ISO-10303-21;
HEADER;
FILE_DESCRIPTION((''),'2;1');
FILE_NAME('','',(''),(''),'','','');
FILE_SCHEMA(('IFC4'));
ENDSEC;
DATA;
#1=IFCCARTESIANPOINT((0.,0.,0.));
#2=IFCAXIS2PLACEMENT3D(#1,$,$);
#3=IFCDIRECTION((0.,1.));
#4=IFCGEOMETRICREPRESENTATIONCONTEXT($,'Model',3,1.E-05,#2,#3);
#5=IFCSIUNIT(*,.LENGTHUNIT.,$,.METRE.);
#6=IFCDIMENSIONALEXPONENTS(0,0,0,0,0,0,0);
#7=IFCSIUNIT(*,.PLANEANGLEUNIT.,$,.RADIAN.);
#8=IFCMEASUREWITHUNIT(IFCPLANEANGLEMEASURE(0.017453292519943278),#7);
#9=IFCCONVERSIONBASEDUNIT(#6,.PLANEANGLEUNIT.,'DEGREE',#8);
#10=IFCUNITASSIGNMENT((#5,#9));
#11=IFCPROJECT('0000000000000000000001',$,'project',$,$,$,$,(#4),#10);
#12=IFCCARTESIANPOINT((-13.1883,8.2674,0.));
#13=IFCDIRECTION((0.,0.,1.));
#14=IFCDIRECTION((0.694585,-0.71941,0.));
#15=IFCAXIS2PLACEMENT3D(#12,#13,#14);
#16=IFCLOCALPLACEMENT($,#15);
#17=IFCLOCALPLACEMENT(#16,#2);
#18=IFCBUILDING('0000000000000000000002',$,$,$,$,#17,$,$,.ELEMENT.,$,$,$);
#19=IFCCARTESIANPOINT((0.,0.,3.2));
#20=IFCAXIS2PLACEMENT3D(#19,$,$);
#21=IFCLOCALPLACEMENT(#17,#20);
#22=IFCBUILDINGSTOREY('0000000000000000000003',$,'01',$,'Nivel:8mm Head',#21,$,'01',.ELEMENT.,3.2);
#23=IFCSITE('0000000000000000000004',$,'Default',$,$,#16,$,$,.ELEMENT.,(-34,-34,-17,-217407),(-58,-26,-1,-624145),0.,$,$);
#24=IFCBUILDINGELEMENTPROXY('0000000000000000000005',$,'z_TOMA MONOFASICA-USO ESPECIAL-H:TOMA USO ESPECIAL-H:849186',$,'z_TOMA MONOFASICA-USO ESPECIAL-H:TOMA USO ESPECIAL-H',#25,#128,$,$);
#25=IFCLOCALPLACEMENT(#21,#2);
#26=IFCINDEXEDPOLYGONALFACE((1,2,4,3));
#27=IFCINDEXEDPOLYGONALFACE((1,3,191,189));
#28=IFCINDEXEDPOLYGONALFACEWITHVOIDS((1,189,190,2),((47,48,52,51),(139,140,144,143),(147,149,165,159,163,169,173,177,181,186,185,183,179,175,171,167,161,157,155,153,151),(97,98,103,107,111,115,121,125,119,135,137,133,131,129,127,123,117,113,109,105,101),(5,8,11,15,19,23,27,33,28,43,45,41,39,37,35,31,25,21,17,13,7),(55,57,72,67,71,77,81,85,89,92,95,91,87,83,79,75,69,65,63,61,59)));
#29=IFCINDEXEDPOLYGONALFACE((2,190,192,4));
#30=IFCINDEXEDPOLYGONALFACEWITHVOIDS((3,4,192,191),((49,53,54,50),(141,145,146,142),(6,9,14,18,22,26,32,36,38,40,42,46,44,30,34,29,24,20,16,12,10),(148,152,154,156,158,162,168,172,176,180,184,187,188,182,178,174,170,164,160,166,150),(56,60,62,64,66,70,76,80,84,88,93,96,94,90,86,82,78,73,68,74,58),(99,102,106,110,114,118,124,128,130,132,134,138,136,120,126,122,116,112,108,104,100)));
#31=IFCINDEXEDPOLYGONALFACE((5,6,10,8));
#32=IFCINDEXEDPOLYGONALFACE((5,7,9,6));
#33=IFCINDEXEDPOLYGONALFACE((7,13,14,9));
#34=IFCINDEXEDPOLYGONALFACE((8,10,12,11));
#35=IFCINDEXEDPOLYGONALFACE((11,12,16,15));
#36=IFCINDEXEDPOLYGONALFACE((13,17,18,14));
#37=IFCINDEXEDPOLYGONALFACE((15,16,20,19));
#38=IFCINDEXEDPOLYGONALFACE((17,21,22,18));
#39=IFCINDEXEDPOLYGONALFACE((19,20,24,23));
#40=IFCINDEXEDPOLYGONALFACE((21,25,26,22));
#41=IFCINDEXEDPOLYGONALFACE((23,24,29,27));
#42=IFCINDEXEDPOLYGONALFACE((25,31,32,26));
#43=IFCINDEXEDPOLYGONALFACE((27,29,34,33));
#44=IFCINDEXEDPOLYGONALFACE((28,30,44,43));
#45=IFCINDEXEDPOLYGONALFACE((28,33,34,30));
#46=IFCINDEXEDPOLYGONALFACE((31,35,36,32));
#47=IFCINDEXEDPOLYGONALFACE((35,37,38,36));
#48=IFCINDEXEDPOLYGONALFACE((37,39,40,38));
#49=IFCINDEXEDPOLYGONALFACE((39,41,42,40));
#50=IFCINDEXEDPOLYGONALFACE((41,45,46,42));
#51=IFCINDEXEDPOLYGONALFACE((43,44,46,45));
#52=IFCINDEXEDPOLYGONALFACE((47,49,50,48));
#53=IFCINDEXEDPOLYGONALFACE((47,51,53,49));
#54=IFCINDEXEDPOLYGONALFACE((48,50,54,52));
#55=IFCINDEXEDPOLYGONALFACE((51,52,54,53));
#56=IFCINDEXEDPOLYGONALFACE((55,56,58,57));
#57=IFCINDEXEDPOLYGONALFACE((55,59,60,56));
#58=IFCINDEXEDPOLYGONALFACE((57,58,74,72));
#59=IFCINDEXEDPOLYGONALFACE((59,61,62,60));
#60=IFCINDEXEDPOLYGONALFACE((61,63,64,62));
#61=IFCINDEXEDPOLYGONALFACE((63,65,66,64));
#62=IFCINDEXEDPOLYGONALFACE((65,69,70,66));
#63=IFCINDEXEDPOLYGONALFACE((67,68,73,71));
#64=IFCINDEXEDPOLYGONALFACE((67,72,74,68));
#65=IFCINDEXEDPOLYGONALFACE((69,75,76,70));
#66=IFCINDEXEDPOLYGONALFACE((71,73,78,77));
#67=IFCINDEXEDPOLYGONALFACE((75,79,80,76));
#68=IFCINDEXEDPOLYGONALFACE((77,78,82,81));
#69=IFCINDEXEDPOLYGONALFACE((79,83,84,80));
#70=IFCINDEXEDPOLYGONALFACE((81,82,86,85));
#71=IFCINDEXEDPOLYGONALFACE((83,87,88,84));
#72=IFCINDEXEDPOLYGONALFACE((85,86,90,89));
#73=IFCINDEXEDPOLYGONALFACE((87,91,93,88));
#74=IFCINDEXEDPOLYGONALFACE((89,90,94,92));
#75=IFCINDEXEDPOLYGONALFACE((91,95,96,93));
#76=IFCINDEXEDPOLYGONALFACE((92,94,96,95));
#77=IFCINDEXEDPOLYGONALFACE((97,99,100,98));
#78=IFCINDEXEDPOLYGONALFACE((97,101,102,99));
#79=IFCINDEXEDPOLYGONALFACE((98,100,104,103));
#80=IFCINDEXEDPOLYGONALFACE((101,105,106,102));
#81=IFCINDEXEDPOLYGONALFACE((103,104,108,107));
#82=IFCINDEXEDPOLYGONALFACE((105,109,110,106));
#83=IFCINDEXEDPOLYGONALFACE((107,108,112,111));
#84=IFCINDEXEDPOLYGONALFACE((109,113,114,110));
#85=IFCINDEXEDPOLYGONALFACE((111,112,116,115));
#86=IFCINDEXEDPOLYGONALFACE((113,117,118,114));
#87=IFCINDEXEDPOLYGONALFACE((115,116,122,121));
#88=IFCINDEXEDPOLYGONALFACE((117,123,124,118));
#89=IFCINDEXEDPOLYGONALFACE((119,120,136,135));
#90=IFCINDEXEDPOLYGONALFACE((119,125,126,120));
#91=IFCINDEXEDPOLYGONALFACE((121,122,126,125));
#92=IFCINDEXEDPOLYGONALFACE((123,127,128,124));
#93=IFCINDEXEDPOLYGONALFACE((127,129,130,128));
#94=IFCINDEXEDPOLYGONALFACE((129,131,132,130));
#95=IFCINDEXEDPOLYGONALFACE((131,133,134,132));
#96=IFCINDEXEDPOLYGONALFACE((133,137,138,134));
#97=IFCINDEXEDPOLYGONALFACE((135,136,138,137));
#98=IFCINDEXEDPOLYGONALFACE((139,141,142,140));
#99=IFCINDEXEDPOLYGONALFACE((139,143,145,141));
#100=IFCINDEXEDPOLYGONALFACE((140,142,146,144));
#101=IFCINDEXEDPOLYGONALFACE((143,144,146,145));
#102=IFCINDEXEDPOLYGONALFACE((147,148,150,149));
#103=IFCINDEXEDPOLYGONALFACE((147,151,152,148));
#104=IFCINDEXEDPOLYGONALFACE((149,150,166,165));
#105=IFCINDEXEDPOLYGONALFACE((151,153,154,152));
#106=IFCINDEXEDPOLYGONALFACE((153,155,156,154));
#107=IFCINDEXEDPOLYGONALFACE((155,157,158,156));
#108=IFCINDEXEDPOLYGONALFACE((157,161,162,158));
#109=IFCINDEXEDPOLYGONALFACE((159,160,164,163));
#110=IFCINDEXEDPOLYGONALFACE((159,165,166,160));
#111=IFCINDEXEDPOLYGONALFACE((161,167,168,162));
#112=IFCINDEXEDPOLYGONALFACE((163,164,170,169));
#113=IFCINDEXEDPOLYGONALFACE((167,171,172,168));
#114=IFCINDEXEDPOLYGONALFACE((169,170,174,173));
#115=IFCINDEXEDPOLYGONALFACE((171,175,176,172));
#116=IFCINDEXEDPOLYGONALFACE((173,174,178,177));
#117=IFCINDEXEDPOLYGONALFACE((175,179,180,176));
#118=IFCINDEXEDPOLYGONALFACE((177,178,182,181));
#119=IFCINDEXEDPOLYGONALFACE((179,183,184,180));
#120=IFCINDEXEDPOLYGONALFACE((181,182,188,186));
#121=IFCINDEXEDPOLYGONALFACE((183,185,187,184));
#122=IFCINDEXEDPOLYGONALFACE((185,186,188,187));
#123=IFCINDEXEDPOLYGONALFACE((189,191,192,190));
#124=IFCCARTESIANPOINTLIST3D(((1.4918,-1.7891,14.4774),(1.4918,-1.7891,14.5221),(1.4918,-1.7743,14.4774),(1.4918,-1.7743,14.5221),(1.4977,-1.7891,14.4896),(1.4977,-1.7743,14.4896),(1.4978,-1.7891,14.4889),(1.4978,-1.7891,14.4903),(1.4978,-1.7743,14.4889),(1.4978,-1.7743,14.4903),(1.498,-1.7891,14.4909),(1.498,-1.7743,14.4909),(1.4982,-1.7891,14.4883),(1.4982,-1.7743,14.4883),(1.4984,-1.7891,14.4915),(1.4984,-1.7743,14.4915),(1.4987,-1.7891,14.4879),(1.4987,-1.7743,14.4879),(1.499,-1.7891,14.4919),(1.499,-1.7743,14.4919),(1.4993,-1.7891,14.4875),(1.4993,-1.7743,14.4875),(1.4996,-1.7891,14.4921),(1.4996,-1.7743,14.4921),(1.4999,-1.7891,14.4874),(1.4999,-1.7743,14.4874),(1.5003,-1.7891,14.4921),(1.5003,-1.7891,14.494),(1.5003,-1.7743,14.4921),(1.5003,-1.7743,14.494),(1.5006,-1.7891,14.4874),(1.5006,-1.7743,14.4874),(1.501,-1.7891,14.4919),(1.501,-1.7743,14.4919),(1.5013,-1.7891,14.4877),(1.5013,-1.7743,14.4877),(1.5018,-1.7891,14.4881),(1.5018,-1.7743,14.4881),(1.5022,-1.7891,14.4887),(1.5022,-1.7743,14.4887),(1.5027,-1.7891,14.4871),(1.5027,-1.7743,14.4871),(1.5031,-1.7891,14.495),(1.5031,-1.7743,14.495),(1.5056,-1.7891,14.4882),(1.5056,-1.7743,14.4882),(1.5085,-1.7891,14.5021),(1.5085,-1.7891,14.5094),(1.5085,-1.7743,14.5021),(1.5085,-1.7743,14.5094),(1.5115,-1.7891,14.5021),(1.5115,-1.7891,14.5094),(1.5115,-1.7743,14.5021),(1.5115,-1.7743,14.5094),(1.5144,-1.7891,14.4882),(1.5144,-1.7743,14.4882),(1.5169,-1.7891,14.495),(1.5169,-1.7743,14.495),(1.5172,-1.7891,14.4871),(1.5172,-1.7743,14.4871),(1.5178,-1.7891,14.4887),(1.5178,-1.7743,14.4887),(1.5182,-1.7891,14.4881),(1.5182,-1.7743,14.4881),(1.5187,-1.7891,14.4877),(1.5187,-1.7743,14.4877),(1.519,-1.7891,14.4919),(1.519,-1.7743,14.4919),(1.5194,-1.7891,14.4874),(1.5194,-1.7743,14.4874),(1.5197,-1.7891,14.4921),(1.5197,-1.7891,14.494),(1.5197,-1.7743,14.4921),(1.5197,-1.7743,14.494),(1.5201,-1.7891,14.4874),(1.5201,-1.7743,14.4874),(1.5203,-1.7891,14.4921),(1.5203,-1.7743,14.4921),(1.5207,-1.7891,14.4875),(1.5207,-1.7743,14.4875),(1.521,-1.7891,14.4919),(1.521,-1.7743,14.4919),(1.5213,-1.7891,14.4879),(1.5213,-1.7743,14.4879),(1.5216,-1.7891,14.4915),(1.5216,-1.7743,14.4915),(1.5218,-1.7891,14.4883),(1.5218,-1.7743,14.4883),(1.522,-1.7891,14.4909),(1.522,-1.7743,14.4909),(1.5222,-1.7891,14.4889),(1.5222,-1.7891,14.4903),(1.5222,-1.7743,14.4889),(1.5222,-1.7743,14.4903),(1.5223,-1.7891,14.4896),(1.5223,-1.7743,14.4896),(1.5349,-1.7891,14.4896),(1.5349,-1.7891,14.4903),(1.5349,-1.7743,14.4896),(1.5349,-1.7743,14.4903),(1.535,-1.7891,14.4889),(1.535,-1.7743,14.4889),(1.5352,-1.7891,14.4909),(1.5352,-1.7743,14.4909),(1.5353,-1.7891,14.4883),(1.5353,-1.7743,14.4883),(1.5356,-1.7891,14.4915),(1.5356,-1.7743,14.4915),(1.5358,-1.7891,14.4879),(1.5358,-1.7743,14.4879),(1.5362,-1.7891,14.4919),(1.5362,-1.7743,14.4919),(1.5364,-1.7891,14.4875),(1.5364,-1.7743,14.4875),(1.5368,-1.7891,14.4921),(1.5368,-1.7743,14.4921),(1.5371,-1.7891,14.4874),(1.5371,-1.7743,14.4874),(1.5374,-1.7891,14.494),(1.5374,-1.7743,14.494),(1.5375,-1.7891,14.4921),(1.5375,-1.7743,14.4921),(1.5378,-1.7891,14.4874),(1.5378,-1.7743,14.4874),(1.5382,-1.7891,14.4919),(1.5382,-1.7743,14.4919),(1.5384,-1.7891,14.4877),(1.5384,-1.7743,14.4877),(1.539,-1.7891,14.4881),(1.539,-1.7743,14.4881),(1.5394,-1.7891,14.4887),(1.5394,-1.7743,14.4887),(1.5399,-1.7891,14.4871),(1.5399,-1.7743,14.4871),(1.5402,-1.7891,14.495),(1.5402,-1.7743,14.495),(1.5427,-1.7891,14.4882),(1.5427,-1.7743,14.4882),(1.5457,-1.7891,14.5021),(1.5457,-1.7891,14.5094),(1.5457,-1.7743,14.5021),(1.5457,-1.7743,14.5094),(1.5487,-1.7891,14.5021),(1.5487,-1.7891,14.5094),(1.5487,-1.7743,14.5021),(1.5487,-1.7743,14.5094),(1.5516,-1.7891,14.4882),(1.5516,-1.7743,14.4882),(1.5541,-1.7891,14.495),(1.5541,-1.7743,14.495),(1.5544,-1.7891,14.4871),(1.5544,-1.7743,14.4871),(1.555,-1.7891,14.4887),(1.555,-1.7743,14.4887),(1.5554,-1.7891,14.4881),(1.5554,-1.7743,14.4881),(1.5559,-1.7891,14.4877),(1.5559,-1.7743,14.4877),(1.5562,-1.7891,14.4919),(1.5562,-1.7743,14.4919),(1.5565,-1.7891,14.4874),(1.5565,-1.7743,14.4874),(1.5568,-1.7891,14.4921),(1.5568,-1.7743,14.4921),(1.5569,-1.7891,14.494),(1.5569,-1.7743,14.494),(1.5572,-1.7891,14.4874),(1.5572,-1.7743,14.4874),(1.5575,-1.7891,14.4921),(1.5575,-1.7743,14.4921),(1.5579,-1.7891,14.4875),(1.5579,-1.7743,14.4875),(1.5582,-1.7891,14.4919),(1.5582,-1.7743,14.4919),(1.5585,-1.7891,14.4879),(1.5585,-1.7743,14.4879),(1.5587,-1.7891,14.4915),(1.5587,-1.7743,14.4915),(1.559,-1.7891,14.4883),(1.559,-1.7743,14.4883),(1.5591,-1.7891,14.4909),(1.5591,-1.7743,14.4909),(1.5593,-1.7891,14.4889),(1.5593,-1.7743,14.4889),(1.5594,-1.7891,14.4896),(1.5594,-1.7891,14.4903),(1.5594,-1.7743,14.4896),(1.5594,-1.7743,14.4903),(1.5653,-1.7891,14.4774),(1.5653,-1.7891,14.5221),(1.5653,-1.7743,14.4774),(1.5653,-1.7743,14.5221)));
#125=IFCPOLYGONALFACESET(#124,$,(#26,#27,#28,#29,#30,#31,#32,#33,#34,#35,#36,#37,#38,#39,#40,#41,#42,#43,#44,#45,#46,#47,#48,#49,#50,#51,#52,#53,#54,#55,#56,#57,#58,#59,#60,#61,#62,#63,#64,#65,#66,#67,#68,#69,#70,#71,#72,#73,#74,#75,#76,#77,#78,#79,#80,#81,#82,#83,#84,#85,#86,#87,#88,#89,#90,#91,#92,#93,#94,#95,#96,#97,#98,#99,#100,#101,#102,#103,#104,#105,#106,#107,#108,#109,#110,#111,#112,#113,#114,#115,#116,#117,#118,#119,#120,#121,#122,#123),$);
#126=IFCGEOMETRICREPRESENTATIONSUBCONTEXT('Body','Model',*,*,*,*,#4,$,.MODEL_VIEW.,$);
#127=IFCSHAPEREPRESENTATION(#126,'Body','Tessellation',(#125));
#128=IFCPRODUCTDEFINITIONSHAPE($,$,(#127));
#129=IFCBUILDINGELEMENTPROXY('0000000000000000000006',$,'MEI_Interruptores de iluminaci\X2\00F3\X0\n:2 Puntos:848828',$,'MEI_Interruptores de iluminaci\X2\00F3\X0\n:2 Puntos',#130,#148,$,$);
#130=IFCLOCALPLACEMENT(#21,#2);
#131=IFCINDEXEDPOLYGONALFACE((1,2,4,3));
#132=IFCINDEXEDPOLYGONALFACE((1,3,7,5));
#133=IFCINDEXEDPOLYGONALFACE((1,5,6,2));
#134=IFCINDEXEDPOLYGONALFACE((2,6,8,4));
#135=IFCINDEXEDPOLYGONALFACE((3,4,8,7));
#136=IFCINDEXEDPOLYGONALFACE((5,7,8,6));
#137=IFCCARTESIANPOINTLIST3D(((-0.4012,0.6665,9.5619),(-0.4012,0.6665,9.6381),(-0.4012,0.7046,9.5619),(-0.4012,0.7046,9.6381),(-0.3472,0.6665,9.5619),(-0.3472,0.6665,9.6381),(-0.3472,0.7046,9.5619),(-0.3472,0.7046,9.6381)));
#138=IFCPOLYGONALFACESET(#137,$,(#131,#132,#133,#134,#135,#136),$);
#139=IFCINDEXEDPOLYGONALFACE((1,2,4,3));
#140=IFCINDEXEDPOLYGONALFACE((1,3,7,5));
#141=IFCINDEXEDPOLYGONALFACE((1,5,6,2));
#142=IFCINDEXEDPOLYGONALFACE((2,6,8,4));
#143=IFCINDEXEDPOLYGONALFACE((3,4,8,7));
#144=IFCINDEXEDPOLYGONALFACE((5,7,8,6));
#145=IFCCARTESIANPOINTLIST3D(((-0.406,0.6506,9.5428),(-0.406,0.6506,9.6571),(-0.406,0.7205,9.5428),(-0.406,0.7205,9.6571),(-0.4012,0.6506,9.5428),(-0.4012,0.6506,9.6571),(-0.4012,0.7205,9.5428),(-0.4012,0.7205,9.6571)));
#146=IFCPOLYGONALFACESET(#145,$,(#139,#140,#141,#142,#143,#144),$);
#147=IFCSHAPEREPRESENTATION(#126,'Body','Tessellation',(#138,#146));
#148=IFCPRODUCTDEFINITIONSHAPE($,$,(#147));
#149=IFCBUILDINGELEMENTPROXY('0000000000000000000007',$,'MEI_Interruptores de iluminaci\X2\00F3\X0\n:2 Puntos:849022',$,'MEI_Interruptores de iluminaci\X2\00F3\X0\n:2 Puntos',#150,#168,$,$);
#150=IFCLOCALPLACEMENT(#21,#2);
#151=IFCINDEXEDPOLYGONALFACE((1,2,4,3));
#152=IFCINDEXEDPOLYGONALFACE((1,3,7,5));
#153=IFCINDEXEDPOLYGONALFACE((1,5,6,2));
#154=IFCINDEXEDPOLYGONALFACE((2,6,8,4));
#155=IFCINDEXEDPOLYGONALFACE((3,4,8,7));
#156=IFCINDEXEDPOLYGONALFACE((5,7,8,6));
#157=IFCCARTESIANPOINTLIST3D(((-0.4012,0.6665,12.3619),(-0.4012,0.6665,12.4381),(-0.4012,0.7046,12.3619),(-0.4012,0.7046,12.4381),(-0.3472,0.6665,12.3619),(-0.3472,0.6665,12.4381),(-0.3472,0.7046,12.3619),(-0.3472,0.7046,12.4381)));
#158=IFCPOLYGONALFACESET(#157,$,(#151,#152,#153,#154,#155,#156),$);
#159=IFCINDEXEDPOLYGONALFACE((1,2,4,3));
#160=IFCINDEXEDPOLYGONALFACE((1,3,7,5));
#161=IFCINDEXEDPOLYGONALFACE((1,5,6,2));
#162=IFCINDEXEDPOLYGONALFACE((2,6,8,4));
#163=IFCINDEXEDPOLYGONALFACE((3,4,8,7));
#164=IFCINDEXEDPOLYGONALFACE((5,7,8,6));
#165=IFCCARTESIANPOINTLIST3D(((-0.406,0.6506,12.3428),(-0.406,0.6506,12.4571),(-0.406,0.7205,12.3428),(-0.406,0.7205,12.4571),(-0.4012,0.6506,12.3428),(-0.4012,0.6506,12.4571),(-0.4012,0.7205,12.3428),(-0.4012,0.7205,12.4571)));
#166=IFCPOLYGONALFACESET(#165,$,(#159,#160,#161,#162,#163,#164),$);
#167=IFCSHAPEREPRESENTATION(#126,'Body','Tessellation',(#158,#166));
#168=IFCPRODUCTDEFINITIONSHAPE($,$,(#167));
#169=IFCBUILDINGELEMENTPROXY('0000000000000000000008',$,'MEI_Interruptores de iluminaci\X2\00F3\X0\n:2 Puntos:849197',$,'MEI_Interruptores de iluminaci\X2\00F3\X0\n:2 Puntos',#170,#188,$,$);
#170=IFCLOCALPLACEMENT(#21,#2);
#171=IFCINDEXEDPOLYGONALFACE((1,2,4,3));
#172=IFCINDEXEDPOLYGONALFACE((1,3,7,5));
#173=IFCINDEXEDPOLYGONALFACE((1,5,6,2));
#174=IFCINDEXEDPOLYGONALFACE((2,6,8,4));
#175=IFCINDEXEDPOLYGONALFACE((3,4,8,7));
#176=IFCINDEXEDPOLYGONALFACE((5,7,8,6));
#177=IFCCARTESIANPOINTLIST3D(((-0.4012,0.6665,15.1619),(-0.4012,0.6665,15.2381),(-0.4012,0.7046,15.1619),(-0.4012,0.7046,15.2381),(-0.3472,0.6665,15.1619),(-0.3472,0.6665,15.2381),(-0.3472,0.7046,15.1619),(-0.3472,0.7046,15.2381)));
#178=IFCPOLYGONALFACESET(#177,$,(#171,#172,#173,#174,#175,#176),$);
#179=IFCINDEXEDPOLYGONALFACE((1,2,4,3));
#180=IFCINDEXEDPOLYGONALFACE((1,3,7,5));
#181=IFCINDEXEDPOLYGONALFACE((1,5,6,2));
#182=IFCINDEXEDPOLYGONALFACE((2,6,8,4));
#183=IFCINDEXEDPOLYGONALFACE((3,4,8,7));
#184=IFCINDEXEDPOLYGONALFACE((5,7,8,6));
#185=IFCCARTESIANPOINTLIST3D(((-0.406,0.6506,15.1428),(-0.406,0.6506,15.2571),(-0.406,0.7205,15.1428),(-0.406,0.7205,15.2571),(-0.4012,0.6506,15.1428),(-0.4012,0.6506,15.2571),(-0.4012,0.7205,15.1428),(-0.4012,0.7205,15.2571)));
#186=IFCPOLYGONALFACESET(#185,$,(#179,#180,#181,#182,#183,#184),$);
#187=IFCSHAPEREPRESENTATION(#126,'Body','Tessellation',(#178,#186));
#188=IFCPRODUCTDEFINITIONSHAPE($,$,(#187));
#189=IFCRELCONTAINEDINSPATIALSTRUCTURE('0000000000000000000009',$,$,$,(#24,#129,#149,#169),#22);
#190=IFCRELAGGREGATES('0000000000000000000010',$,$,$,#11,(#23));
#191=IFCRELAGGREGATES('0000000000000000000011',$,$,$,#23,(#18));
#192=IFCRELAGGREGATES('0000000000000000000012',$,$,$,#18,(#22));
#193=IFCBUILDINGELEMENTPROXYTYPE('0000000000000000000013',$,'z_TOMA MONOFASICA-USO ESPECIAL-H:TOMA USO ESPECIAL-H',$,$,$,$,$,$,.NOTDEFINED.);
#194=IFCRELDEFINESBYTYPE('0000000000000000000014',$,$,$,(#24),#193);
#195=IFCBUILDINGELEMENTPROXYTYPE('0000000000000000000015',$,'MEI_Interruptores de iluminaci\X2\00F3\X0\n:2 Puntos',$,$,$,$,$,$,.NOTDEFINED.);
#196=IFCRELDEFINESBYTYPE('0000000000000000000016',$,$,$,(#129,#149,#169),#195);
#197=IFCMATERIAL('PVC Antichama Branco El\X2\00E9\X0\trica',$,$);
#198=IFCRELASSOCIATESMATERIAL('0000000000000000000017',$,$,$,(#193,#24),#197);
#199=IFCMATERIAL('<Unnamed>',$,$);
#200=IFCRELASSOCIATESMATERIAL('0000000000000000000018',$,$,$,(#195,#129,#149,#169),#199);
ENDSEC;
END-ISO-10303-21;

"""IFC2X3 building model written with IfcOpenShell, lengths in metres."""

from ifc_helpers import new_model, entity, si_unit, converted_unit, direction, frame, frame_2d, origin, origin_2d_with_axis, place, context, subcontext, project, spatial, polyline, circle_curve, parameter, trimmed, segment, composite_curve, rectangle, outline, extrude, source, transform, mapped, material, type_object, type_shapes, element, save


model = new_model("IFC2X3")

# Units and contexts
model_context = context("Model", 3, precision=1e-05, world=origin(), true_north=direction((0.0, 1.0)))
body_context = subcontext(model_context, "Body", "Model", "MODEL_VIEW")
ifc_project = project(units=[si_unit("LENGTHUNIT", "METRE"), converted_unit("PLANEANGLEUNIT", "DEGREE", entity("IfcPlaneAngleMeasure", 0.017453292519943278), si_unit("PLANEANGLEUNIT", "RADIAN"), dimensions=[0, 0, 0, 0, 0, 0, 0])], contexts=[model_context])

# Site, building, storey
site_placement = place(None, frame((-13.1883, 8.2674, 0.0), z_axis=(0.0, 0.0, 1.0), x_axis=(0.694585, -0.71941, 0.0)))
site = spatial("IfcSite", under=ifc_project, at=site_placement, Name="Default", CompositionType="ELEMENT", RefLatitude=(-34, -34, -17, -217407), RefLongitude=(-58, -26, -1, -624145), RefElevation=0.0)
building_placement = place(site_placement, origin())
building = spatial("IfcBuilding", under=site, at=building_placement, CompositionType="ELEMENT")
storey_placement = place(building_placement, frame((0.0, 0.0, 3.2)))
storey = spatial("IfcBuildingStorey", under=building, at=storey_placement, Name="01", ObjectType="Nivel:8mm Head", LongName="01", CompositionType="ELEMENT", Elevation=3.2)

# Building element proxies
ifc_material_1 = material(Name="PVC Antichama Branco Elétrica")
building_element_proxy_type_1 = type_object("IfcBuildingElementProxyType", Name="z_TOMA MONOFASICA-USO ESPECIAL-H:TOMA USO ESPECIAL-H", PredefinedType="NOTDEFINED", material=ifc_material_1)
shared_shape_1 = source(origin(), body_context, "Body", "SweptSolid", [
    extrude(outline(polyline([(-0.0368, -0.0223), (0.0368, -0.0223), (0.0368, 0.0223), (-0.0368, 0.0223), (-0.0368, -0.0223)]), holes=[composite_curve([segment(polyline([(0.0141, 0.0115), (0.0116, 0.0047)]), True, "CONTINUOUS"), segment(polyline([(0.0116, 0.0047), (0.0088, 0.0057)]), True, "CONTINUOUS"), segment(polyline([(0.0088, 0.0057), (0.0096, 0.0078)]), True, "CONTINUOUS"), segment(trimmed(circle_curve(frame_2d((0.0087, 0.0099), x_axis=(1.0, 0.0)), 0.0024), [parameter(27.118901)], [parameter(292.881099)], True, "PARAMETER"), False, "CONTINUOUS"), segment(polyline([(0.0108, 0.011), (0.0113, 0.0126)]), True, "CONTINUOUS"), segment(polyline([(0.0113, 0.0126), (0.0141, 0.0115)]), True, "CONTINUOUS")], self_intersect=False), composite_curve([segment(polyline([(0.0255, 0.0047), (0.023, 0.0115)]), True, "CONTINUOUS"), segment(polyline([(0.023, 0.0115), (0.0258, 0.0126)]), True, "CONTINUOUS"), segment(polyline([(0.0258, 0.0126), (0.0264, 0.011)]), True, "CONTINUOUS"), segment(trimmed(circle_curve(frame_2d((0.0285, 0.0099), x_axis=(1.0, 0.0)), 0.0024), [parameter(247.118901)], [parameter(152.881099)], True, "PARAMETER"), False, "CONTINUOUS"), segment(polyline([(0.0276, 0.0078), (0.0283, 0.0057)]), True, "CONTINUOUS"), segment(polyline([(0.0283, 0.0057), (0.0255, 0.0047)]), True, "CONTINUOUS")], self_intersect=False), polyline([(0.0201, -0.0024), (0.0201, -0.0097), (0.0171, -0.0097), (0.0171, -0.0024), (0.0201, -0.0024)]), composite_curve([segment(polyline([(-0.0141, 0.0115), (-0.0113, 0.0126)]), True, "CONTINUOUS"), segment(polyline([(-0.0113, 0.0126), (-0.0108, 0.011)]), True, "CONTINUOUS"), segment(trimmed(circle_curve(frame_2d((-0.0087, 0.0099), x_axis=(1.0, 0.0)), 0.0024), [parameter(247.118901)], [parameter(152.881099)], True, "PARAMETER"), False, "CONTINUOUS"), segment(polyline([(-0.0096, 0.0078), (-0.0088, 0.0057)]), True, "CONTINUOUS"), segment(polyline([(-0.0088, 0.0057), (-0.0116, 0.0047)]), True, "CONTINUOUS"), segment(polyline([(-0.0116, 0.0047), (-0.0141, 0.0115)]), True, "CONTINUOUS")], self_intersect=False), composite_curve([segment(polyline([(-0.0255, 0.0047), (-0.0283, 0.0057)]), True, "CONTINUOUS"), segment(polyline([(-0.0283, 0.0057), (-0.0276, 0.0078)]), True, "CONTINUOUS"), segment(trimmed(circle_curve(frame_2d((-0.0285, 0.0099), x_axis=(1.0, 0.0)), 0.0024), [parameter(27.118901)], [parameter(292.881099)], True, "PARAMETER"), False, "CONTINUOUS"), segment(polyline([(-0.0264, 0.011), (-0.0258, 0.0126)]), True, "CONTINUOUS"), segment(polyline([(-0.0258, 0.0126), (-0.023, 0.0115)]), True, "CONTINUOUS"), segment(polyline([(-0.023, 0.0115), (-0.0255, 0.0047)]), True, "CONTINUOUS")], self_intersect=False), polyline([(-0.0201, -0.0024), (-0.0171, -0.0024), (-0.0171, -0.0097), (-0.0201, -0.0097), (-0.0201, -0.0024)])]), frame((0.0, -0.005, 0.0223), z_axis=(0.0, 1.0, 0.0), x_axis=(1.0, 0.0, 0.0)), (0.0, 0.0, 1.0), 0.0148),
])
type_shapes(building_element_proxy_type_1, [shared_shape_1])
for number, where, z_axis, x_axis, name in (
    (1, (1.5286, -1.7793, 14.4774), (0.0, 0.0, 1.0), (-1.0, 0.0, 0.0), "z_TOMA MONOFASICA-USO ESPECIAL-H:TOMA USO ESPECIAL-H:849186"),
):
    element("IfcBuildingElementProxy", number, at=place(storey_placement, frame(where, z_axis=z_axis, x_axis=x_axis)), inside=storey, type_object=building_element_proxy_type_1, material=ifc_material_1, Name=name, ObjectType="z_TOMA MONOFASICA-USO ESPECIAL-H:TOMA USO ESPECIAL-H", context=body_context, shape_type="MappedRepresentation", body=[
        mapped(shared_shape_1, transform((0.0, 0.0, 0.0), scale=1.0)),
    ])
ifc_material_2 = material(Name="<Unnamed>")
building_element_proxy_type_2 = type_object("IfcBuildingElementProxyType", Name="MEI_Interruptores de iluminación:2 Puntos", PredefinedType="NOTDEFINED", material=ifc_material_2)
shared_shape_2 = source(origin(), body_context, "Body", "SweptSolid", [
    extrude(rectangle(XDim=0.0381, YDim=0.0762, at=origin_2d_with_axis()), frame((0.0, 0.0, -0.054), z_axis=(0.0, 0.0, 1.0), x_axis=(-1.0, 0.0, 0.0)), (0.0, 0.0, 1.0), 0.054),
    extrude(rectangle(XDim=0.0698, YDim=0.1143, at=frame_2d((0.0, 0.0), x_axis=(1.0, 0.0))), frame((0.0, 0.0, 0.0), z_axis=(0.0, 0.0, 1.0), x_axis=(-1.0, 0.0, 0.0)), (0.0, 0.0, 1.0), 0.0048),
])
type_shapes(building_element_proxy_type_2, [shared_shape_2])
for number, where, z_axis, x_axis, name in (
    (2, (-0.4012, 0.6856, 9.6), (-1.0, 0.0, 0.0), (0.0, -1.0, 0.0), "MEI_Interruptores de iluminación:2 Puntos:848828"),
    (3, (-0.4012, 0.6856, 12.4), (-1.0, 0.0, 0.0), (0.0, -1.0, 0.0), "MEI_Interruptores de iluminación:2 Puntos:849022"),
    (4, (-0.4012, 0.6856, 15.2), (-1.0, 0.0, 0.0), (0.0, -1.0, 0.0), "MEI_Interruptores de iluminación:2 Puntos:849197"),
):
    element("IfcBuildingElementProxy", number, at=place(storey_placement, frame(where, z_axis=z_axis, x_axis=x_axis)), inside=storey, type_object=building_element_proxy_type_2, material=ifc_material_2, Name=name, ObjectType="MEI_Interruptores de iluminación:2 Puntos", context=body_context, shape_type="MappedRepresentation", body=[
        mapped(shared_shape_2, transform((0.0, 0.0, 0.0), scale=1.0)),
    ])

save(model, "model.ifc")
